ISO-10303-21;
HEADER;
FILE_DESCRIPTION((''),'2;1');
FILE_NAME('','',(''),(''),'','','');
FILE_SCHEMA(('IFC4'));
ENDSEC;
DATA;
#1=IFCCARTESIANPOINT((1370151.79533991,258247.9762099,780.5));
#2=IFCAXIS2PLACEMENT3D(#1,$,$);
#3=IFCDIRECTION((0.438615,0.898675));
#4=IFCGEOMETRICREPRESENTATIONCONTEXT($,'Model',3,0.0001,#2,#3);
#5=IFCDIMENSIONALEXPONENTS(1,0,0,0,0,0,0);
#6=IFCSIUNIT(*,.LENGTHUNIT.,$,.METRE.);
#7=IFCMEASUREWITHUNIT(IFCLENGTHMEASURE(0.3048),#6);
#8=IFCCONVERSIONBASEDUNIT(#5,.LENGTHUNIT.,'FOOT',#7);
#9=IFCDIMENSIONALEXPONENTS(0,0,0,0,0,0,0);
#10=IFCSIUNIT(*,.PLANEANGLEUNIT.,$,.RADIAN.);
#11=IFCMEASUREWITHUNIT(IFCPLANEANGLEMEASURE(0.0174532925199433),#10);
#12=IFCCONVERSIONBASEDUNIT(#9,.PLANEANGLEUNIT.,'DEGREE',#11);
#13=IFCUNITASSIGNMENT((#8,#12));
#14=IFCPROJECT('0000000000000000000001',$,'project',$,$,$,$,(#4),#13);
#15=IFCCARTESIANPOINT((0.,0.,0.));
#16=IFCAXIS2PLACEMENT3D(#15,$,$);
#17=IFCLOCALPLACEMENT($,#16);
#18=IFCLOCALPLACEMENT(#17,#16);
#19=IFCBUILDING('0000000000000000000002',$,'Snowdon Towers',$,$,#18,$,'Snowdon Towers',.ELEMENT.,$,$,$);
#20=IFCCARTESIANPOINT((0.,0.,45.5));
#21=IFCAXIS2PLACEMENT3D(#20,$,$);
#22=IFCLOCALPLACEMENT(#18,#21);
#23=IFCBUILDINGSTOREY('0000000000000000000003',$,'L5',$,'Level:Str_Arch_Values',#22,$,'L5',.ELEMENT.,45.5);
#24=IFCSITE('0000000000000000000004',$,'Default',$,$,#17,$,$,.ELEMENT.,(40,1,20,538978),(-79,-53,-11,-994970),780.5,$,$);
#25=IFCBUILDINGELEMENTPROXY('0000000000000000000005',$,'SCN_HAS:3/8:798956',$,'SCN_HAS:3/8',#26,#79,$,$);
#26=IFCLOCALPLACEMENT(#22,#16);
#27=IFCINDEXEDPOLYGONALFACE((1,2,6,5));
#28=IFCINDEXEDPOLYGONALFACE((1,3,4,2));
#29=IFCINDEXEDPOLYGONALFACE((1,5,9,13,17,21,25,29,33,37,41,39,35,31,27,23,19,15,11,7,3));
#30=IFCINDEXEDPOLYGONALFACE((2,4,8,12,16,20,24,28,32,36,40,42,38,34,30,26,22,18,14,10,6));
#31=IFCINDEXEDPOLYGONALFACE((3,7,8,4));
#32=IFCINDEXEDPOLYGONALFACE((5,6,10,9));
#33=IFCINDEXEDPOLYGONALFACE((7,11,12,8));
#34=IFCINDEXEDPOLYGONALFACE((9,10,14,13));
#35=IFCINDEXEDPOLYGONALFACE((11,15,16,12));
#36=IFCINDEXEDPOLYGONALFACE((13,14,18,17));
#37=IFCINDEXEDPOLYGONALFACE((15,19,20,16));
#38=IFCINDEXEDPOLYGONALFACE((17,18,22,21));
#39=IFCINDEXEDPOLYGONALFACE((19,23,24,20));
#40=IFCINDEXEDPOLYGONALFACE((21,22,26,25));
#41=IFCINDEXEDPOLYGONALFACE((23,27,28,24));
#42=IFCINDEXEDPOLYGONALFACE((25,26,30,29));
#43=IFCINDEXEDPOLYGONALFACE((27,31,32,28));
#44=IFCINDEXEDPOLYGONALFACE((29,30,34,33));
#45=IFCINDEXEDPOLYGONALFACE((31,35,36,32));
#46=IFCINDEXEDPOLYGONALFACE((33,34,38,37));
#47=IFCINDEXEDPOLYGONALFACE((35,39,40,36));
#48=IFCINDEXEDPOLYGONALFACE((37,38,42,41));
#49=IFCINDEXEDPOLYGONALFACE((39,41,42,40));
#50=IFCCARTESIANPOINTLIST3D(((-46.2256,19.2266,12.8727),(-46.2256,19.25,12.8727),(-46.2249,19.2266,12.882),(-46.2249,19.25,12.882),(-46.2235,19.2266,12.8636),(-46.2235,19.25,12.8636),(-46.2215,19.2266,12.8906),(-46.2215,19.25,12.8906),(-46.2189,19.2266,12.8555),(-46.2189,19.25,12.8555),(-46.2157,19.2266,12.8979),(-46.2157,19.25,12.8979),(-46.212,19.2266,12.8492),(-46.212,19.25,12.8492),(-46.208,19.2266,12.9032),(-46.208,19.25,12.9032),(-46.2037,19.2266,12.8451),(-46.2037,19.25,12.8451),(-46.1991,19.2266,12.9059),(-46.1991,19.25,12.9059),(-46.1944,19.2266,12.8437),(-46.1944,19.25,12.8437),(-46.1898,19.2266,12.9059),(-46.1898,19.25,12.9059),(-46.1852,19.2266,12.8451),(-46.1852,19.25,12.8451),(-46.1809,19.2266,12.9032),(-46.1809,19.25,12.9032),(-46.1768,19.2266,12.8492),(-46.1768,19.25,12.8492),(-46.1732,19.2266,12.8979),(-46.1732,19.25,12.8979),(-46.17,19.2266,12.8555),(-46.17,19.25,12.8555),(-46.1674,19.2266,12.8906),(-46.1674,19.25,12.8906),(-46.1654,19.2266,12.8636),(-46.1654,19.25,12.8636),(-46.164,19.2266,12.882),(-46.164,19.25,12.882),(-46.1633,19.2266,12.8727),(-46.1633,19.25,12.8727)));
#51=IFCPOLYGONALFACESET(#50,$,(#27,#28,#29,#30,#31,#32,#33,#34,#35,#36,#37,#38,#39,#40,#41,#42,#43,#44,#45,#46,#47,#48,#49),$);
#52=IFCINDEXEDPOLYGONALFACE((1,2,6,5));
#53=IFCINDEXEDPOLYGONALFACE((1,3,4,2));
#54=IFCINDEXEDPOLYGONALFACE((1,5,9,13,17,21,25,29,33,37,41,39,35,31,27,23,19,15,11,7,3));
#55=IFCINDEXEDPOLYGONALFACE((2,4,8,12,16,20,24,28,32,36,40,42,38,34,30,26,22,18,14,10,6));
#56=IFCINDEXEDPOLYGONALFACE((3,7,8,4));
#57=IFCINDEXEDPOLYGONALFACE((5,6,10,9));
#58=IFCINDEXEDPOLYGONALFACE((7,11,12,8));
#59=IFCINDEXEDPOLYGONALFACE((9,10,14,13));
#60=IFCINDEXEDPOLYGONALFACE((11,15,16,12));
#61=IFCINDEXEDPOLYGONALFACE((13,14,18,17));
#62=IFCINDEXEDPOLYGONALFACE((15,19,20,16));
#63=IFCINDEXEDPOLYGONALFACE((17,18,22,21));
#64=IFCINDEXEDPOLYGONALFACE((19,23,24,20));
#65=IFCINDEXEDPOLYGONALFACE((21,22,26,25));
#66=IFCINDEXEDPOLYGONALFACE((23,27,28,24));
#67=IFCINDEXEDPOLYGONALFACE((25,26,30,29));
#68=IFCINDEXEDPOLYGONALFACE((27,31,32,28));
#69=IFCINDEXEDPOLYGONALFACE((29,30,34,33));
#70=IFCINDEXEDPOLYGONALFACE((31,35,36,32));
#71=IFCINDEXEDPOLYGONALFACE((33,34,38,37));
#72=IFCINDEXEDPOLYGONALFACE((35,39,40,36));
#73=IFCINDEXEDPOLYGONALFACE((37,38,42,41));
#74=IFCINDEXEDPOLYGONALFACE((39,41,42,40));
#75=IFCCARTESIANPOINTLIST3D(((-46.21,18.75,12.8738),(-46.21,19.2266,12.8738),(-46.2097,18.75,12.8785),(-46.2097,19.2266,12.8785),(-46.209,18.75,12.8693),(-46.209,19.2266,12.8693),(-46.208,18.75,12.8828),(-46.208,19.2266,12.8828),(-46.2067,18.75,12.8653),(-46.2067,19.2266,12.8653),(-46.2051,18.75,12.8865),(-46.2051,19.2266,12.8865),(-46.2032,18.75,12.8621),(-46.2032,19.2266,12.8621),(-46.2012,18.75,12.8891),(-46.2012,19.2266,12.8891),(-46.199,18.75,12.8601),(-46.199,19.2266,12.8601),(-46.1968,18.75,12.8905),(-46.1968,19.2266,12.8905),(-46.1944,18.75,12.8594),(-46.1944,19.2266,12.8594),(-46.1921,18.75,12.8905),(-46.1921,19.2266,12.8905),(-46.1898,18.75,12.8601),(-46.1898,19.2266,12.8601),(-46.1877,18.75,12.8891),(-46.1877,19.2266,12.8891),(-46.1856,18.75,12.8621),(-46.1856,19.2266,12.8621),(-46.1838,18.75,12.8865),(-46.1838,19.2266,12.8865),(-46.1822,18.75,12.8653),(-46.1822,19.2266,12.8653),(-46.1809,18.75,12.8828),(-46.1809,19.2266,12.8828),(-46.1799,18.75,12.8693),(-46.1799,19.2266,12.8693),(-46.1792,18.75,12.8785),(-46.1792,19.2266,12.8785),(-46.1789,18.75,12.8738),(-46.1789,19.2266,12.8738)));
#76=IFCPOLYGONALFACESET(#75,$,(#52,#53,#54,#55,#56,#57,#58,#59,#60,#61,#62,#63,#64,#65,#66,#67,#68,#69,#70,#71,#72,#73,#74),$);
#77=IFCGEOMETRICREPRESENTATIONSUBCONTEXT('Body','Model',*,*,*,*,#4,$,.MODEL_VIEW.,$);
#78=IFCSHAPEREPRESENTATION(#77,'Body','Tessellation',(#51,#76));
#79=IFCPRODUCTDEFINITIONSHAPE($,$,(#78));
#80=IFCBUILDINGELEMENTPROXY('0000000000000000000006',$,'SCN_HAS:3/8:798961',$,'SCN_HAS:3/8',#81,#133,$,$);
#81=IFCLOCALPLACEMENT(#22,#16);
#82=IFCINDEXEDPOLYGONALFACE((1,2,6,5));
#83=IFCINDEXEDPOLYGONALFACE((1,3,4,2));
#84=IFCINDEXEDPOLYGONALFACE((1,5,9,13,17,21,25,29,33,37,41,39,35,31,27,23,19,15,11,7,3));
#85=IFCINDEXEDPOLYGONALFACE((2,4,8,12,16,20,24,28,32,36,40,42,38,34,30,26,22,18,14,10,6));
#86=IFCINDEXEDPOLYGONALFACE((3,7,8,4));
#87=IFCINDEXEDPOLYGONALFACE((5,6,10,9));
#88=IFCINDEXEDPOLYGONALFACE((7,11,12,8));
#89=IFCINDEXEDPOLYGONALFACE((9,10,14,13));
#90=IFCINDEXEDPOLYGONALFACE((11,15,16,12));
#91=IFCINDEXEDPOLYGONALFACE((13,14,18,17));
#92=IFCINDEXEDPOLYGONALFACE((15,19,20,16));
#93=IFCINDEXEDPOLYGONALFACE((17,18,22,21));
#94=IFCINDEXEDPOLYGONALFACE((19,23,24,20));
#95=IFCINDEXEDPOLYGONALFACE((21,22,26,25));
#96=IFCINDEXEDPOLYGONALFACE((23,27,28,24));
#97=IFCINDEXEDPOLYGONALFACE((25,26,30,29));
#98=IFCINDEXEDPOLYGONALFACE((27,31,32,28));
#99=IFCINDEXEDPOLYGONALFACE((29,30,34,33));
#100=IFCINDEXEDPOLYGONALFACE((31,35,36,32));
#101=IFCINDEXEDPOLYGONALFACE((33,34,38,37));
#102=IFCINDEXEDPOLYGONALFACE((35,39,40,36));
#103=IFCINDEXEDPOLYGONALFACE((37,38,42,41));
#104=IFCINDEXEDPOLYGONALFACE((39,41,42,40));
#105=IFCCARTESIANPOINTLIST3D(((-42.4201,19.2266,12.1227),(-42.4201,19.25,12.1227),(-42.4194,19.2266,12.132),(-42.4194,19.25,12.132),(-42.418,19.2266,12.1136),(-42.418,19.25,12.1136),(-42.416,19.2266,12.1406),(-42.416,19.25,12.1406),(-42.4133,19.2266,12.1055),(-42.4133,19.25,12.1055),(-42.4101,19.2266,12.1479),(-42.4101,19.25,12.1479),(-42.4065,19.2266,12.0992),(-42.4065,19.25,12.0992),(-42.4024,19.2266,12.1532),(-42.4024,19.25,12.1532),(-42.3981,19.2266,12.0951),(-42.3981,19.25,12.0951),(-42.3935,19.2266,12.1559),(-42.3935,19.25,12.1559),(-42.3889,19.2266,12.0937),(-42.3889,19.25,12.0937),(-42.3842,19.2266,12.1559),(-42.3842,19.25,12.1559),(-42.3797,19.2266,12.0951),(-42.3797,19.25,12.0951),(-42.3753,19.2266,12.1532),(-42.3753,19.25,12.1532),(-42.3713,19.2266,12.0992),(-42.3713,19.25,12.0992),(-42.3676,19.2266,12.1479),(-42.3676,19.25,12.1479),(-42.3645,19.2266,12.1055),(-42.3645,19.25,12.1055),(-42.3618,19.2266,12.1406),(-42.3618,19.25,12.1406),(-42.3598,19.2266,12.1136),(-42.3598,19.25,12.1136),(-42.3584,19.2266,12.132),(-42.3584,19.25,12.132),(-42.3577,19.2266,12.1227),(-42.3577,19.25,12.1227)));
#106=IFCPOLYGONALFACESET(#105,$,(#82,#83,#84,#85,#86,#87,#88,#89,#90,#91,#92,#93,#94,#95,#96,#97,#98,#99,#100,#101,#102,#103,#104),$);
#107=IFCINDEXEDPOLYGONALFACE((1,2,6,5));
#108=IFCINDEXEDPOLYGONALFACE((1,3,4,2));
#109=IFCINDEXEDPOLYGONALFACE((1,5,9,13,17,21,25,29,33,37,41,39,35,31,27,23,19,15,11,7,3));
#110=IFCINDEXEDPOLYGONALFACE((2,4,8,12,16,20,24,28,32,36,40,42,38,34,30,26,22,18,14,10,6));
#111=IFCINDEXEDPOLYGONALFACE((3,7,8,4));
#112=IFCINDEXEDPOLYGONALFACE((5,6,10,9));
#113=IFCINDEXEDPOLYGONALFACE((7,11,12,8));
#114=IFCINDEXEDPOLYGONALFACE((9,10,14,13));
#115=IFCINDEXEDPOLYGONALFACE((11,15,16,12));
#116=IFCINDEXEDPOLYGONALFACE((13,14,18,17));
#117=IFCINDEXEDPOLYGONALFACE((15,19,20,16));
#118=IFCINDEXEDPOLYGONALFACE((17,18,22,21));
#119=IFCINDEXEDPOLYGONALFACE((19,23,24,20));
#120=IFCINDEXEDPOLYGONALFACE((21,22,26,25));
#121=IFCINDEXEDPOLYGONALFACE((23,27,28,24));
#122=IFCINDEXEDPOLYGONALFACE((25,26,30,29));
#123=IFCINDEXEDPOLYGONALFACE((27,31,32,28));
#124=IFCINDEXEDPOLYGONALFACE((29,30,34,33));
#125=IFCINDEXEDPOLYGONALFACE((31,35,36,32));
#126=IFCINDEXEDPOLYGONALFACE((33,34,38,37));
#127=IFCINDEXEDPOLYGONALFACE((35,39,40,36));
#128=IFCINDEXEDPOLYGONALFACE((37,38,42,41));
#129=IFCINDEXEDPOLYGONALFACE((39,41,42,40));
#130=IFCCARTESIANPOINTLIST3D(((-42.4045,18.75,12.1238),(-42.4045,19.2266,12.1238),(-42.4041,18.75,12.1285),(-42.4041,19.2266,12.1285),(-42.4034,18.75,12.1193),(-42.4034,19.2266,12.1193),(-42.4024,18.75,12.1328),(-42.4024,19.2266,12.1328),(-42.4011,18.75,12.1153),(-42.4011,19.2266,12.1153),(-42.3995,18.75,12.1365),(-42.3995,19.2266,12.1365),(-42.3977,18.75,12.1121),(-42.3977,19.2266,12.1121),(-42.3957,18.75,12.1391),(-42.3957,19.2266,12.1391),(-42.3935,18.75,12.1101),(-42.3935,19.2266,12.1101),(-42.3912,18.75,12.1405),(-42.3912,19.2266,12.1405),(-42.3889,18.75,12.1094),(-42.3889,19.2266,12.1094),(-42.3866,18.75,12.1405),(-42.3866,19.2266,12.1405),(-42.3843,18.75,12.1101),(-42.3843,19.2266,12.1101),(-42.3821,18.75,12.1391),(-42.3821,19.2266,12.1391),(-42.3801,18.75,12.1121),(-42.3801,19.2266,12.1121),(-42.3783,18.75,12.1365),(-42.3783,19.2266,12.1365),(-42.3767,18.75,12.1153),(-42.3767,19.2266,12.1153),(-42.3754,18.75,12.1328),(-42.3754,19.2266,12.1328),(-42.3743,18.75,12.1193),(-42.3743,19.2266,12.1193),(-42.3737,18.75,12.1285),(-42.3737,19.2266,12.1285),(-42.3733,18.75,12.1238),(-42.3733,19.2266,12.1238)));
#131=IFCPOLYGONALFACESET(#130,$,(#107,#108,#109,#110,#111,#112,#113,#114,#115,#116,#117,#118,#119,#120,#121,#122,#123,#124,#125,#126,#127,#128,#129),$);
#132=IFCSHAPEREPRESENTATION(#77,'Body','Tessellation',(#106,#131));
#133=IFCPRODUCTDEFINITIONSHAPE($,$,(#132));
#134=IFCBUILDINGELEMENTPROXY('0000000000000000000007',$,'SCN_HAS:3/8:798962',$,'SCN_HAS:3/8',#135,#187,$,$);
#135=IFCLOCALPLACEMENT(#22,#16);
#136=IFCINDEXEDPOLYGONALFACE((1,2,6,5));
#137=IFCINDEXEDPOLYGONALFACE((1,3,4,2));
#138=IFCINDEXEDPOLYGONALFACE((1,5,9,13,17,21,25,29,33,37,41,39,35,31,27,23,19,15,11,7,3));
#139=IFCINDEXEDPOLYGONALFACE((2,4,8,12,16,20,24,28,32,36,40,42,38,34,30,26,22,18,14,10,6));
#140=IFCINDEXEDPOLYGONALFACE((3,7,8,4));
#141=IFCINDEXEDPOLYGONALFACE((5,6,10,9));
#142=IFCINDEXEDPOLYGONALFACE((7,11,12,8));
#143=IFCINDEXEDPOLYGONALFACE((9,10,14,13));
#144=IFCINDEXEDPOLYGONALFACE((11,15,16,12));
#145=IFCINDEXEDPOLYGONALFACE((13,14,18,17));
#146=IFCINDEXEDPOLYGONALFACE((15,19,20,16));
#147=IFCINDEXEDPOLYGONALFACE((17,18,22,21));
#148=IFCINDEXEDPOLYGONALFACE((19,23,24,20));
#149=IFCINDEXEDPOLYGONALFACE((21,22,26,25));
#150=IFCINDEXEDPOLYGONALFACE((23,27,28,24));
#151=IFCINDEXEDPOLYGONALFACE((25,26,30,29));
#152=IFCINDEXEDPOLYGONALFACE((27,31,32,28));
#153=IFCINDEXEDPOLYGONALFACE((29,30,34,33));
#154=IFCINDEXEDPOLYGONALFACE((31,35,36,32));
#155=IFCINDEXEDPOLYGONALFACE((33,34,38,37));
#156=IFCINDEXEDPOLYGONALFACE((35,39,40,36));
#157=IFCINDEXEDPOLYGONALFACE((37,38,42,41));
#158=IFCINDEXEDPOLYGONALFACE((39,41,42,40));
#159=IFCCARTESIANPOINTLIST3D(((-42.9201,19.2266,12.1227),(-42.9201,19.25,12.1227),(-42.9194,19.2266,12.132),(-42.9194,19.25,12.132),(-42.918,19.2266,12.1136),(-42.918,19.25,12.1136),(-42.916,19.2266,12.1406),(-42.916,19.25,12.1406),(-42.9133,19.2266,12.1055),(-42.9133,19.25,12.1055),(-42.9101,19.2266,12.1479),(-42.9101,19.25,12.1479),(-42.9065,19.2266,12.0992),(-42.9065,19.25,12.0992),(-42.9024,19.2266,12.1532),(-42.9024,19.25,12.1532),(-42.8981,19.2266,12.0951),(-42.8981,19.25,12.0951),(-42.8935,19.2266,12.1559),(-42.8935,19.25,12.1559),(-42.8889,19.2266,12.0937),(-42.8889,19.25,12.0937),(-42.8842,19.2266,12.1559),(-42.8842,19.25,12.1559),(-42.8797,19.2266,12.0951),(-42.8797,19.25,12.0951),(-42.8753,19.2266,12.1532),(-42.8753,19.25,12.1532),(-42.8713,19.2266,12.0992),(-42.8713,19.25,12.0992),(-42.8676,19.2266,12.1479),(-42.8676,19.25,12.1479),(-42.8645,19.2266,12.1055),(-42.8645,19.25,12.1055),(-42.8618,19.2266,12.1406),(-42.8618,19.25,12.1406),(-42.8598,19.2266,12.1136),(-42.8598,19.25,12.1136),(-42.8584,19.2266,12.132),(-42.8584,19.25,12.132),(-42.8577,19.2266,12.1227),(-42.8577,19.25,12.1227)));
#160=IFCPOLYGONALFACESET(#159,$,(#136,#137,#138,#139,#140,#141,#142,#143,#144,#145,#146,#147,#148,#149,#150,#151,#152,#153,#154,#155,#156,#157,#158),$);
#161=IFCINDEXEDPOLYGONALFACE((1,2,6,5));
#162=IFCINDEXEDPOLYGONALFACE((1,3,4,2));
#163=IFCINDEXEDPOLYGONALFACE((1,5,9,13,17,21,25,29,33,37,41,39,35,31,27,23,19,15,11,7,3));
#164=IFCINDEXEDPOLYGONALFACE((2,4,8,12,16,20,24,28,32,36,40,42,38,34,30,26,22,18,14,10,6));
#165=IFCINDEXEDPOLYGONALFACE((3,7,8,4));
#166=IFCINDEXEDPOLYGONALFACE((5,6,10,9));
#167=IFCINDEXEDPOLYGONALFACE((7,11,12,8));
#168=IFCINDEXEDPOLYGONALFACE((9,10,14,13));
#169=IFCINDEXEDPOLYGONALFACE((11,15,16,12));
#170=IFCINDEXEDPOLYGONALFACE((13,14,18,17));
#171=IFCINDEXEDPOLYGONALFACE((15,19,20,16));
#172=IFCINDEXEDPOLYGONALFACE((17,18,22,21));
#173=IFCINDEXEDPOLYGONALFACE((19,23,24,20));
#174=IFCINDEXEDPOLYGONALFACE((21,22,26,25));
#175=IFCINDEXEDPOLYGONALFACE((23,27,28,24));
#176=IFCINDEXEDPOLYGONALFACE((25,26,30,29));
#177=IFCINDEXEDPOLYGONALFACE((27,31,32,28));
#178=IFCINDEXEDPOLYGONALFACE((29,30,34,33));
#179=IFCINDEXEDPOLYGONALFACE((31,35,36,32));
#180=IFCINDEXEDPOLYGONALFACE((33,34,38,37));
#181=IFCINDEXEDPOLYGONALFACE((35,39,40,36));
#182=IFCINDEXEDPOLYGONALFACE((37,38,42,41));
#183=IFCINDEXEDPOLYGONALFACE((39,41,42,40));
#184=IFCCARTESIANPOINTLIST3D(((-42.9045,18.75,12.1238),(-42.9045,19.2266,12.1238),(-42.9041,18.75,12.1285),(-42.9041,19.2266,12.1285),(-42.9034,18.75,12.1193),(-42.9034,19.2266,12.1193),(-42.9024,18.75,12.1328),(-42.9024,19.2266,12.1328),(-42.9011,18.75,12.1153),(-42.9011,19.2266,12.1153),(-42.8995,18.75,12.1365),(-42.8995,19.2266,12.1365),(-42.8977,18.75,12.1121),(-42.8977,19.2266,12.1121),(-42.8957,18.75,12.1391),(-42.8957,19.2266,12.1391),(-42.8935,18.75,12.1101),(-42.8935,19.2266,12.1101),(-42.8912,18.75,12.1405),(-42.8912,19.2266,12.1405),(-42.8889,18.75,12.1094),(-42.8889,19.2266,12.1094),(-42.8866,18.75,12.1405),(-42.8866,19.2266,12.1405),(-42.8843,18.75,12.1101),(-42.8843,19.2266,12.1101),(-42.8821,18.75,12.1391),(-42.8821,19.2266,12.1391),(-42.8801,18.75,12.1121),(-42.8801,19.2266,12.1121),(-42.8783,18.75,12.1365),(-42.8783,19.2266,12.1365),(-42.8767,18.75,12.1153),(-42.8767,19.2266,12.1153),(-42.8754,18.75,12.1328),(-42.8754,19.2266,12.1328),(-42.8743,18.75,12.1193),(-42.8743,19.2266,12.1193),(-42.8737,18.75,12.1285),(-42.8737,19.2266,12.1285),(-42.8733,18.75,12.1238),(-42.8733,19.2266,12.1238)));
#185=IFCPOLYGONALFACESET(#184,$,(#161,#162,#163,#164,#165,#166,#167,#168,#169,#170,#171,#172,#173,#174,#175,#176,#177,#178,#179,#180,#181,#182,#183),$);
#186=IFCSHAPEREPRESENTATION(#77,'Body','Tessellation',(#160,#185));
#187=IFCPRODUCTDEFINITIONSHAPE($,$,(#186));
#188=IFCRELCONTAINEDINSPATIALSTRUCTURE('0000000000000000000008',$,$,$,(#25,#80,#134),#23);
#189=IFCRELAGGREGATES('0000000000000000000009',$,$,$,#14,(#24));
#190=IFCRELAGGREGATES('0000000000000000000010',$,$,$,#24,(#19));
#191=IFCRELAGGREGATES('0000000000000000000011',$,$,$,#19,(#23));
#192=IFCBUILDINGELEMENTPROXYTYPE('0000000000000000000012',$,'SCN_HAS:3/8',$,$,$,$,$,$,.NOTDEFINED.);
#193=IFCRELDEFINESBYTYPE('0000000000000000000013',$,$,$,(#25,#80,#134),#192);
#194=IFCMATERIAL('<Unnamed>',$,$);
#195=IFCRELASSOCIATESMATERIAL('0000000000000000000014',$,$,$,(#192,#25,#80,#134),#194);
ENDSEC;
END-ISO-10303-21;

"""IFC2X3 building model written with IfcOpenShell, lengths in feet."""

from ifc_helpers import new_model, entity, si_unit, converted_unit, direction, frame, frame_2d, origin, place, context, subcontext, project, spatial, circle, extrude, source, transform, mapped, material, type_object, type_shapes, element, save


model = new_model("IFC2X3")

# Units and contexts
model_context = context("Model", 3, precision=0.0001, world=frame((1370151.79533991, 258247.9762099, 780.5)), true_north=direction((0.438615, 0.898675)))
body_context = subcontext(model_context, "Body", "Model", "MODEL_VIEW")
ifc_project = project(units=[converted_unit("LENGTHUNIT", "FOOT", entity("IfcLengthMeasure", 0.3048), si_unit("LENGTHUNIT", "METRE"), dimensions=[1, 0, 0, 0, 0, 0, 0]), converted_unit("PLANEANGLEUNIT", "DEGREE", entity("IfcPlaneAngleMeasure", 0.0174532925199433), si_unit("PLANEANGLEUNIT", "RADIAN"), dimensions=[0, 0, 0, 0, 0, 0, 0])], contexts=[model_context])

# Site, building, storey
site_placement = place(None, origin())
site = spatial("IfcSite", under=ifc_project, at=site_placement, Name="Default", CompositionType="ELEMENT", RefLatitude=(40, 1, 20, 538978), RefLongitude=(-79, -53, -11, -994970), RefElevation=780.5)
building_placement = place(site_placement, origin())
building = spatial("IfcBuilding", under=site, at=building_placement, Name="Snowdon Towers", LongName="Snowdon Towers", CompositionType="ELEMENT")
storey_placement = place(building_placement, frame((0.0, 0.0, 45.5)))
storey = spatial("IfcBuildingStorey", under=building, at=storey_placement, Name="L5", ObjectType="Level:Str_Arch_Values", LongName="L5", CompositionType="ELEMENT", Elevation=45.5)

# Building element proxies
ifc_material_1 = material(Name="<Unnamed>")
building_element_proxy_type = type_object("IfcBuildingElementProxyType", Name="SCN_HAS:3/8", PredefinedType="NOTDEFINED", material=ifc_material_1)
shared_shape = source(origin(), body_context, "Body", "SweptSolid", [
    extrude(circle(Radius=0.0312, at=frame_2d((0.0, 0.0), x_axis=(1.0, 0.0))), frame((0.0, 0.0, -0.5), z_axis=(0.0, 0.0, 1.0), x_axis=(0.0, -1.0, 0.0)), (0.0, 0.0, 1.0), 0.0234),
    extrude(circle(Radius=0.0156, at=frame_2d((0.0, 0.0), x_axis=(1.0, 0.0))), frame((0.0, 0.0, -0.4766), z_axis=(0.0, 0.0, 1.0), x_axis=(0.0, -1.0, 0.0)), (0.0, 0.0, 1.0), 0.4766),
])
type_shapes(building_element_proxy_type, [shared_shape])
for number, where, z_axis, x_axis, name in (
    (1, (-46.1944, 18.75, 12.875), (0.0, -1.0, 0.0), (1.0, 0.0, 0.0), "SCN_HAS:3/8:798956"),
    (2, (-42.3889, 18.75, 12.125), (0.0, -1.0, 0.0), (1.0, 0.0, 0.0), "SCN_HAS:3/8:798961"),
    (3, (-42.8889, 18.75, 12.125), (0.0, -1.0, 0.0), (1.0, 0.0, 0.0), "SCN_HAS:3/8:798962"),
):
    element("IfcBuildingElementProxy", number, at=place(storey_placement, frame(where, z_axis=z_axis, x_axis=x_axis)), inside=storey, type_object=building_element_proxy_type, material=ifc_material_1, Name=name, ObjectType="SCN_HAS:3/8", context=body_context, shape_type="MappedRepresentation", body=[
        mapped(shared_shape, transform((0.0, 0.0, 0.0), scale=1.0)),
    ])

save(model, "model.ifc")
